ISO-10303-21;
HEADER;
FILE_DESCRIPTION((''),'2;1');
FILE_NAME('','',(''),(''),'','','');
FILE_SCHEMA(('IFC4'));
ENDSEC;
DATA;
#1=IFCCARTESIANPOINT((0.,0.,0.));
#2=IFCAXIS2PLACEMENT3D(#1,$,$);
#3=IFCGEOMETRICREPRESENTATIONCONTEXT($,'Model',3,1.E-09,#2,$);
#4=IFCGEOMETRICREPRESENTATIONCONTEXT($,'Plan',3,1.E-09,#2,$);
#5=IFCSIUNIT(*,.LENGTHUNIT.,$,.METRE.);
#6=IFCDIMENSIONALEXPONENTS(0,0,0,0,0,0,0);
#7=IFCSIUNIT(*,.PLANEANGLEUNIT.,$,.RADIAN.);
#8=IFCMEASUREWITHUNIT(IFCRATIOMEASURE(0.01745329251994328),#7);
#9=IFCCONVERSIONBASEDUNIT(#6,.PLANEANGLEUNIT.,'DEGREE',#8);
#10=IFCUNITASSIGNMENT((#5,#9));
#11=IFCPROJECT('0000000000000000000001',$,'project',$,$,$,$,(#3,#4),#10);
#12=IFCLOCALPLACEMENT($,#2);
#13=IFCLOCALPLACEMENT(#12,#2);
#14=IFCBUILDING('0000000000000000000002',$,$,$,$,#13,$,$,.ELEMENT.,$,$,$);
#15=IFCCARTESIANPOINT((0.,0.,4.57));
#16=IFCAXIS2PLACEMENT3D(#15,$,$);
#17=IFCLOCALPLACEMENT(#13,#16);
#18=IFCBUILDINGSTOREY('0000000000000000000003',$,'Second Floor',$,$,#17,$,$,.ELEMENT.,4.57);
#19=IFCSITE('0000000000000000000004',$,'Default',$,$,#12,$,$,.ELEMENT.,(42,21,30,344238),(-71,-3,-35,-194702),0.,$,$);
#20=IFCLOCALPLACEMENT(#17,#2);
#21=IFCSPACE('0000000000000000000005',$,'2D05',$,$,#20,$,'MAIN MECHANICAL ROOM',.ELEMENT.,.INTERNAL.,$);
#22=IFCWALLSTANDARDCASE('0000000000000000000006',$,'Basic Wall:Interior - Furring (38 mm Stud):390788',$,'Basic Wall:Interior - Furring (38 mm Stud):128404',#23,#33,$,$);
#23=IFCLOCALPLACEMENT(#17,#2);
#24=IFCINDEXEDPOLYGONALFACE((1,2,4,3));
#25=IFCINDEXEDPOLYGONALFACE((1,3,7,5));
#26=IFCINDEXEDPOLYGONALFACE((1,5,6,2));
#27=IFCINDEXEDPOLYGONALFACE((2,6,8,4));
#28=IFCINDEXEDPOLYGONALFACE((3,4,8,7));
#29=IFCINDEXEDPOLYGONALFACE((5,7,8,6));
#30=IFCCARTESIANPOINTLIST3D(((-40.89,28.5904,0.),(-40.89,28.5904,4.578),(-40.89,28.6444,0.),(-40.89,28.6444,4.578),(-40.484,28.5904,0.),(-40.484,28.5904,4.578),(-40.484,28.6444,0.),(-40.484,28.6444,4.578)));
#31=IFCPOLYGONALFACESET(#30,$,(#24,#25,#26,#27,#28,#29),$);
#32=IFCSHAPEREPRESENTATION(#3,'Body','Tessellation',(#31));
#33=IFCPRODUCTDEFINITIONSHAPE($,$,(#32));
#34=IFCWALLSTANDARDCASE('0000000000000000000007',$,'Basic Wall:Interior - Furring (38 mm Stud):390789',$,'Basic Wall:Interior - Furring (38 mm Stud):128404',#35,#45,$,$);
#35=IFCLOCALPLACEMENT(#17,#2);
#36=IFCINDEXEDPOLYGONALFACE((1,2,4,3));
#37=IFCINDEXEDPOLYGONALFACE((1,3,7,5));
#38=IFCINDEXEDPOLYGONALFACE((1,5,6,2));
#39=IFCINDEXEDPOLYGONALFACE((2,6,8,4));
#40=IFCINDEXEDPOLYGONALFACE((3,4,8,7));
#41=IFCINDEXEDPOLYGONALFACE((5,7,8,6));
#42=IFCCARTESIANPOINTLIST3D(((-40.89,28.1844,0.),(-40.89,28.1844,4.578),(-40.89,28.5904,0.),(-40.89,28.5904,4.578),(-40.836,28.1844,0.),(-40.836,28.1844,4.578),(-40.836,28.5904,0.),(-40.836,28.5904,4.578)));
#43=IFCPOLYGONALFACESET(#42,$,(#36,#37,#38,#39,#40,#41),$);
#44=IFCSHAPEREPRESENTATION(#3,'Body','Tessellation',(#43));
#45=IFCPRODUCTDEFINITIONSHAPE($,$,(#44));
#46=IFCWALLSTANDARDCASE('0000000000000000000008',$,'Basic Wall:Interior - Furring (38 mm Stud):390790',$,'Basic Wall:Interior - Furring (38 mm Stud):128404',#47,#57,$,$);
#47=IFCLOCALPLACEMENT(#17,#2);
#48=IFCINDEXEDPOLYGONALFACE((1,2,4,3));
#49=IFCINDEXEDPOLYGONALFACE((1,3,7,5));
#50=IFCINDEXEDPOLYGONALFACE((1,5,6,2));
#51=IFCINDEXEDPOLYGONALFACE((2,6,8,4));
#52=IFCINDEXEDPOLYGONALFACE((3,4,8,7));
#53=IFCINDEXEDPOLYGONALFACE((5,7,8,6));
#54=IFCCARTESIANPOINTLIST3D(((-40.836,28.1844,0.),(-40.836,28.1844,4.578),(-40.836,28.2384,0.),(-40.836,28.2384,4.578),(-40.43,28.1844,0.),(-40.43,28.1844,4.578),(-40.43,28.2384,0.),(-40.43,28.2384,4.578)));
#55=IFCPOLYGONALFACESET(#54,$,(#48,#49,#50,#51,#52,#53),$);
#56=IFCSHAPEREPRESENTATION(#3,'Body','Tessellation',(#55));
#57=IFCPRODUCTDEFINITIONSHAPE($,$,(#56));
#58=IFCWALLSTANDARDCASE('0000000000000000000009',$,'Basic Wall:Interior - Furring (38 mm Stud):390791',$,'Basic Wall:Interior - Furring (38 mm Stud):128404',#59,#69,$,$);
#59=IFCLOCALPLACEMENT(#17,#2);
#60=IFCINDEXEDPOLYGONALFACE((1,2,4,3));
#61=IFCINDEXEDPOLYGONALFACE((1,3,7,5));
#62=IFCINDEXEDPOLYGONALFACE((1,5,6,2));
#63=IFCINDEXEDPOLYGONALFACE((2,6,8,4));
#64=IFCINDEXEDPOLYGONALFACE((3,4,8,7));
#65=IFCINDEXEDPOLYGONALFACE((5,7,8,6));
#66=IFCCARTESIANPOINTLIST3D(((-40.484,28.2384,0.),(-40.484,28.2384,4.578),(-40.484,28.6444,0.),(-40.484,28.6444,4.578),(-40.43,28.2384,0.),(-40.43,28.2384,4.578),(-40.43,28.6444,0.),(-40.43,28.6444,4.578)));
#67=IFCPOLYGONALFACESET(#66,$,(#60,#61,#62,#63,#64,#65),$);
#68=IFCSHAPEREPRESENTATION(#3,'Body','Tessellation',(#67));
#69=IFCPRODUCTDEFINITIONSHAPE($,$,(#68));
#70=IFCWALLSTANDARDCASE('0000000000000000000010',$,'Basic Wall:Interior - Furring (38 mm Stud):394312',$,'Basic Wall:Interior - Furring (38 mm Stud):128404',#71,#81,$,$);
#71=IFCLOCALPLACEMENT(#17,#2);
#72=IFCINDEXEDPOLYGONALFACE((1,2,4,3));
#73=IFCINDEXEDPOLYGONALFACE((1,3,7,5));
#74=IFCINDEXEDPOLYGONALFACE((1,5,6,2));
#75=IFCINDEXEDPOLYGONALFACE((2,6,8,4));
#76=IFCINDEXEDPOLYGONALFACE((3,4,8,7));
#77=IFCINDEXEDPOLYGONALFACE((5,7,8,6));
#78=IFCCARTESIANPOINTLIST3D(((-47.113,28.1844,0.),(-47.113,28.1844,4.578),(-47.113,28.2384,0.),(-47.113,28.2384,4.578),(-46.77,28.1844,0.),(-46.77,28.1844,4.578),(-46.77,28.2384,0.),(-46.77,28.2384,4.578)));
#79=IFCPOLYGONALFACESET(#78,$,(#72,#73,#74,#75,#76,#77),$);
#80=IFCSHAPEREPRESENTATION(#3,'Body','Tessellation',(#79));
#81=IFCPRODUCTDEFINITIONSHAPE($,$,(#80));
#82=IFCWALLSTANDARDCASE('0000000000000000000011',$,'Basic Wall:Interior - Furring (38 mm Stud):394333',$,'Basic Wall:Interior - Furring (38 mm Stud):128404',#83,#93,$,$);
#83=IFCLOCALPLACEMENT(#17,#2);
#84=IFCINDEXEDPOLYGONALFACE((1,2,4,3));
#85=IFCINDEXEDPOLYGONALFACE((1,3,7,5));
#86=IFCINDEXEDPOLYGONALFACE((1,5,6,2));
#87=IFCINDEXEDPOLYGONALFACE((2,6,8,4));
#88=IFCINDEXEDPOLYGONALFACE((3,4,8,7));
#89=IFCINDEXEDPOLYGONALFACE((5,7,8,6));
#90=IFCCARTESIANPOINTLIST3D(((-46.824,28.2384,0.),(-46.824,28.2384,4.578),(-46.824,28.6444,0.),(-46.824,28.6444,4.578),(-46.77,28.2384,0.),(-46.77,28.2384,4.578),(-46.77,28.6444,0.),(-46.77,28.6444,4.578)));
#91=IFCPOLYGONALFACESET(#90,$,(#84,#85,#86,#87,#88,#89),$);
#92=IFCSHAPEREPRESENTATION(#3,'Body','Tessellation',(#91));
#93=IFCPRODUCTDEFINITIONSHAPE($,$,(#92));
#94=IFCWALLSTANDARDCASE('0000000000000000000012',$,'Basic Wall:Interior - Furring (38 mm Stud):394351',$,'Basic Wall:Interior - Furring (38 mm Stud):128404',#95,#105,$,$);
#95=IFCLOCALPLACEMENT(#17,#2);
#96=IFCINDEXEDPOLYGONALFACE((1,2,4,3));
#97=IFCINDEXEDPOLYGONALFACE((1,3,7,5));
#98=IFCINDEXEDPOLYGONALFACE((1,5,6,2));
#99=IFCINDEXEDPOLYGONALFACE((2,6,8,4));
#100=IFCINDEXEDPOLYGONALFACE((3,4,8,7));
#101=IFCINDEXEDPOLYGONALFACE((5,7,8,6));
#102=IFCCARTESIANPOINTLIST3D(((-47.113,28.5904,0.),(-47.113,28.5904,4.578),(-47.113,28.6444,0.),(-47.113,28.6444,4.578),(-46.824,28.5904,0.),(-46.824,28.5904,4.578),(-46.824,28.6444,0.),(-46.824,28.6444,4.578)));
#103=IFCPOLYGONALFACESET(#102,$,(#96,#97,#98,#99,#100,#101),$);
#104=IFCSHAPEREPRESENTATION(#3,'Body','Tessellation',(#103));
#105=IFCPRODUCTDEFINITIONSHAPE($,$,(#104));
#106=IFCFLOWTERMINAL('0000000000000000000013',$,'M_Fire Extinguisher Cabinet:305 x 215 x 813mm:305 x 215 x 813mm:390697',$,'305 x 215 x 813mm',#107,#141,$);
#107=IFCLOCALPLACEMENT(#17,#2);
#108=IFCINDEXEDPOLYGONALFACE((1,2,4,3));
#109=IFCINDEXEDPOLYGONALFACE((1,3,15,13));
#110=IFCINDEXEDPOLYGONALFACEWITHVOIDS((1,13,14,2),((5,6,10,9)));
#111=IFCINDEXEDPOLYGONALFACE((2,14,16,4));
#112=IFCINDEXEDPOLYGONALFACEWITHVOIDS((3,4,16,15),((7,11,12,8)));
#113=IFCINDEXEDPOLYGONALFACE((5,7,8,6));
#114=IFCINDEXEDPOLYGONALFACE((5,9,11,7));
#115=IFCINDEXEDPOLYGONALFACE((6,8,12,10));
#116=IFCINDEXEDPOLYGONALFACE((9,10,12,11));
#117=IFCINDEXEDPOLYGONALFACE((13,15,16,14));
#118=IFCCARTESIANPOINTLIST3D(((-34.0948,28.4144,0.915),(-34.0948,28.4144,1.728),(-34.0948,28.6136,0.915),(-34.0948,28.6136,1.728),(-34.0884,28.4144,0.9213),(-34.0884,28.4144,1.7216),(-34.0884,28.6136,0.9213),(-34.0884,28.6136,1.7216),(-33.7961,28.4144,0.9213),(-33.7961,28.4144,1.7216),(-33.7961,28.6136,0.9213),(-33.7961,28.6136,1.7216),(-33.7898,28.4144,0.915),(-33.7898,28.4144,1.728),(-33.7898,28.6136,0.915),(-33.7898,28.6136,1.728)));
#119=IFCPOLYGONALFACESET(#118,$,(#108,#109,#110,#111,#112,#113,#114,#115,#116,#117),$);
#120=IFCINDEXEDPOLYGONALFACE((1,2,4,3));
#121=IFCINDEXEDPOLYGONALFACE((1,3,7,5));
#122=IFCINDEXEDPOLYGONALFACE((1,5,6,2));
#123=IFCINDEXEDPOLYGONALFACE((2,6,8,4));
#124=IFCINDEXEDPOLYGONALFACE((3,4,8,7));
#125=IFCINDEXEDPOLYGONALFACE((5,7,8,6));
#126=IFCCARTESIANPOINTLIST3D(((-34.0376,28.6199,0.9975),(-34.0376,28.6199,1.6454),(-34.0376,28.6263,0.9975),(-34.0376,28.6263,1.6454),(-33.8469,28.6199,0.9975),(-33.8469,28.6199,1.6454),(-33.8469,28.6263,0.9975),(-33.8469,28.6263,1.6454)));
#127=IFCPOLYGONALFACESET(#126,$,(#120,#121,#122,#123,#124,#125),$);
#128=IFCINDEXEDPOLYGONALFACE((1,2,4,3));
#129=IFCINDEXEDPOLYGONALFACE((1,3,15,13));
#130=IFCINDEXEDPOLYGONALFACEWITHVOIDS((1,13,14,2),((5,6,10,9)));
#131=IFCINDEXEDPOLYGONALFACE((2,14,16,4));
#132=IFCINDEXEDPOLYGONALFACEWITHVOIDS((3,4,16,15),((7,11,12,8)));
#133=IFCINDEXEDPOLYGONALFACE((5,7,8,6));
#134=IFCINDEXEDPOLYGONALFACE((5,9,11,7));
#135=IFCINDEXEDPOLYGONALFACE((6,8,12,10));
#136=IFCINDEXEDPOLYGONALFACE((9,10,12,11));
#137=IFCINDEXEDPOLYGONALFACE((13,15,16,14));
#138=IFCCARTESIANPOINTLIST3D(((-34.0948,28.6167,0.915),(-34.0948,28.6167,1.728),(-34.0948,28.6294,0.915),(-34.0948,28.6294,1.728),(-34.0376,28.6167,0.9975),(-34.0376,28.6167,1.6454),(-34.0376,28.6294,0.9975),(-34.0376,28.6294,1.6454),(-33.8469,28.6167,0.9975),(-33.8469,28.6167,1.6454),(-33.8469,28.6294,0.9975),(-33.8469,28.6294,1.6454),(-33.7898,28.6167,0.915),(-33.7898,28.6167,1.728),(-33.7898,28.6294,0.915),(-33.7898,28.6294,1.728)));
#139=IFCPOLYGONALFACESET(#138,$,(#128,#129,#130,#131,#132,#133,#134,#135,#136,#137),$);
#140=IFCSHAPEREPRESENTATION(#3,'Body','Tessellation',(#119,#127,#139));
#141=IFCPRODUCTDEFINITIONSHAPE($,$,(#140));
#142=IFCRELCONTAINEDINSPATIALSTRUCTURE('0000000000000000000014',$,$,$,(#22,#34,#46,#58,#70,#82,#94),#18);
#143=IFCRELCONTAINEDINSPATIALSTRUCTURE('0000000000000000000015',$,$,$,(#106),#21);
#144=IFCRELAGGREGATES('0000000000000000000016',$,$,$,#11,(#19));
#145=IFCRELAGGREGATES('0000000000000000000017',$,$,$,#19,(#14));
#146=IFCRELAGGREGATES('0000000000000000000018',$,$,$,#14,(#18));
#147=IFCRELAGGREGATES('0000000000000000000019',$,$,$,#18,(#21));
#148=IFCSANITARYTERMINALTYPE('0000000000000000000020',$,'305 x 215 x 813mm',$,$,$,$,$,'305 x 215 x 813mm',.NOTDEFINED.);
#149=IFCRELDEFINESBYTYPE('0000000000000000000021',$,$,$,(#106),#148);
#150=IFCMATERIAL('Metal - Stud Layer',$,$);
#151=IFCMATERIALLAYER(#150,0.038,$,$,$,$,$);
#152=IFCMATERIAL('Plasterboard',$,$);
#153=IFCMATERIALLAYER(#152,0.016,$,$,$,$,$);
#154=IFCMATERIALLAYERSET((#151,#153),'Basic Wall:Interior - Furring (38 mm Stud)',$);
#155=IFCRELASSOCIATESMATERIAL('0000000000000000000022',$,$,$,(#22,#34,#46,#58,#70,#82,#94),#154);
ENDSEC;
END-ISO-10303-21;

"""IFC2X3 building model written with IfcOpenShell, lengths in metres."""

from ifc_helpers import new_model, entity, si_unit, converted_unit, frame, frame_2d, origin, origin_2d_with_axis, place, context, project, spatial, polyline, rectangle, outline, extrude, source, transform, mapped, material, layer, layer_set, layer_usage, type_object, type_shapes, element, save


model = new_model("IFC2X3")

# Units and contexts
model_context = context("Model", 3, precision=1e-09, world=origin())
plan_context = context("Plan", 3, precision=1e-09, world=origin())
ifc_project = project(units=[si_unit("LENGTHUNIT", "METRE"), converted_unit("PLANEANGLEUNIT", "DEGREE", entity("IfcRatioMeasure", 0.01745329251994328), si_unit("PLANEANGLEUNIT", "RADIAN"), dimensions=[0, 0, 0, 0, 0, 0, 0])], contexts=[model_context, plan_context])

# Site, building, storey
site_placement = place(None, origin())
site = spatial("IfcSite", under=ifc_project, at=site_placement, Name="Default", CompositionType="ELEMENT", RefLatitude=(42, 21, 30, 344238), RefLongitude=(-71, -3, -35, -194702), RefElevation=0.0)
building_placement = place(site_placement, origin())
building = spatial("IfcBuilding", under=site, at=building_placement, CompositionType="ELEMENT")
storey_placement = place(building_placement, frame((0.0, 0.0, 4.57)))
storey = spatial("IfcBuildingStorey", under=building, at=storey_placement, Name="Second Floor", CompositionType="ELEMENT", Elevation=4.57)

# Shared definitions
ifc_material_1 = material(Name="Plasterboard")
ifc_layer_1 = layer(ifc_material_1, 0.016)
ifc_material_2 = material(Name="Metal - Stud Layer")
ifc_layer_2 = layer(ifc_material_2, 0.038)
ifc_layer_set_1 = layer_set([ifc_layer_2, ifc_layer_1], Name="Basic Wall:Interior - Furring (38 mm Stud)")
ifc_layer_usage_1 = layer_usage(ifc_layer_set_1, "AXIS2", "NEGATIVE", 0.027)

# Walls
ifc_layer_usage_2 = layer_usage(ifc_layer_set_1, "AXIS2", "POSITIVE", -0.027)
wall_1_placement = place(storey_placement, frame((-40.89, 28.6174, 0.0)))
element("IfcWallStandardCase", 1, at=wall_1_placement, inside=storey, material=ifc_layer_usage_2, Name="Basic Wall:Interior - Furring (38 mm Stud):390788", ObjectType="Basic Wall:Interior - Furring (38 mm Stud):128404", context=model_context, shape_type="SweptSolid", body=[
    extrude(rectangle(XDim=0.406, YDim=0.054, at=frame_2d((0.203, 0.0), x_axis=(-1.0, 0.0))), origin(), (0.0, 0.0, 1.0), 4.578),
])
wall_2_placement = place(storey_placement, frame((-40.863, 28.1844, 0.0), z_axis=(0.0, 0.0, 1.0), x_axis=(0.0, 1.0, 0.0)))
element("IfcWallStandardCase", 2, at=wall_2_placement, inside=storey, material=ifc_layer_usage_2, Name="Basic Wall:Interior - Furring (38 mm Stud):390789", ObjectType="Basic Wall:Interior - Furring (38 mm Stud):128404", context=model_context, shape_type="SweptSolid", body=[
    extrude(rectangle(XDim=0.406, YDim=0.054, at=frame_2d((0.203, 0.0), x_axis=(-1.0, 0.0))), origin(), (0.0, 0.0, 1.0), 4.578),
])
wall_3_placement = place(storey_placement, frame((-40.43, 28.2114, 0.0), z_axis=(0.0, 0.0, 1.0), x_axis=(-1.0, 0.0, 0.0)))
element("IfcWallStandardCase", 3, at=wall_3_placement, inside=storey, material=ifc_layer_usage_2, Name="Basic Wall:Interior - Furring (38 mm Stud):390790", ObjectType="Basic Wall:Interior - Furring (38 mm Stud):128404", context=model_context, shape_type="SweptSolid", body=[
    extrude(rectangle(XDim=0.406, YDim=0.054, at=frame_2d((0.203, 0.0), x_axis=(-1.0, 0.0))), origin(), (0.0, 0.0, 1.0), 4.578),
])
wall_4_placement = place(storey_placement, frame((-40.457, 28.6444, 0.0), z_axis=(0.0, 0.0, 1.0), x_axis=(0.0, -1.0, 0.0)))
element("IfcWallStandardCase", 4, at=wall_4_placement, inside=storey, material=ifc_layer_usage_2, Name="Basic Wall:Interior - Furring (38 mm Stud):390791", ObjectType="Basic Wall:Interior - Furring (38 mm Stud):128404", context=model_context, shape_type="SweptSolid", body=[
    extrude(rectangle(XDim=0.406, YDim=0.054, at=frame_2d((0.203, 0.0), x_axis=(-1.0, 0.0))), origin(), (0.0, 0.0, 1.0), 4.578),
])
wall_5_placement = place(storey_placement, frame((-47.113, 28.2114, 0.0)))
element("IfcWallStandardCase", 5, at=wall_5_placement, inside=storey, material=ifc_layer_usage_1, Name="Basic Wall:Interior - Furring (38 mm Stud):394312", ObjectType="Basic Wall:Interior - Furring (38 mm Stud):128404", context=model_context, shape_type="SweptSolid", body=[
    extrude(rectangle(XDim=0.343, YDim=0.054, at=frame_2d((0.1715, 0.0), x_axis=(-1.0, 0.0))), origin(), (0.0, 0.0, 1.0), 4.578),
])
wall_6_placement = place(storey_placement, frame((-46.797, 28.2384, 0.0), z_axis=(0.0, 0.0, 1.0), x_axis=(0.0, 1.0, 0.0)))
element("IfcWallStandardCase", 6, at=wall_6_placement, inside=storey, material=ifc_layer_usage_1, Name="Basic Wall:Interior - Furring (38 mm Stud):394333", ObjectType="Basic Wall:Interior - Furring (38 mm Stud):128404", context=model_context, shape_type="SweptSolid", body=[
    extrude(rectangle(XDim=0.406, YDim=0.054, at=frame_2d((0.203, 0.0), x_axis=(-1.0, 0.0))), origin(), (0.0, 0.0, 1.0), 4.578),
])
wall_7_placement = place(storey_placement, frame((-46.824, 28.6174, 0.0), z_axis=(0.0, 0.0, 1.0), x_axis=(-1.0, 0.0, 0.0)))
element("IfcWallStandardCase", 7, at=wall_7_placement, inside=storey, material=ifc_layer_usage_1, Name="Basic Wall:Interior - Furring (38 mm Stud):394351", ObjectType="Basic Wall:Interior - Furring (38 mm Stud):128404", context=model_context, shape_type="SweptSolid", body=[
    extrude(rectangle(XDim=0.289, YDim=0.054, at=frame_2d((0.1445, 0.0), x_axis=(-1.0, 0.0))), origin(), (0.0, 0.0, 1.0), 4.578),
])

# Shared definitions
space_placement = place(storey_placement, origin())
space = spatial("IfcSpace", under=storey, at=space_placement, Name="2D05", LongName="MAIN MECHANICAL ROOM", CompositionType="ELEMENT", InteriorOrExteriorSpace="INTERNAL")

# Flow terminal
sanitary_terminal_type = type_object("IfcSanitaryTerminalType", Name="305 x 215 x 813mm", ElementType="305 x 215 x 813mm", PredefinedType="NOTDEFINED")
shared_shape_1 = source(origin(), model_context, "Body", "SweptSolid", [
    extrude(outline(polyline([(-0.1525, -0.4065), (0.1525, -0.4065), (0.1525, 0.4065), (-0.1525, 0.4065), (-0.1525, -0.4065)]), holes=[polyline([(-0.1462, -0.4001), (-0.1462, 0.4002), (0.1462, 0.4002), (0.1462, -0.4001), (-0.1462, -0.4001)])]), frame((-0.1096, 0.027, 1.3215), z_axis=(0.0, 1.0, 0.0), x_axis=(1.0, 0.0, 0.0)), (0.0, 0.0, 1.0), 0.1991),
    extrude(rectangle(XDim=0.0064, YDim=0.1907, at=origin_2d_with_axis()), frame((-0.1096, 0.2356, 0.9975), z_axis=(0.0, 0.0, 1.0), x_axis=(0.0, -1.0, 0.0)), (0.0, 0.0, 1.0), 0.6479),
    extrude(outline(polyline([(-0.1525, -0.4065), (0.1525, -0.4065), (0.1525, 0.4065), (-0.1525, 0.4065), (-0.1525, -0.4065)]), holes=[polyline([(-0.0953, -0.3239), (-0.0953, 0.324), (0.0954, 0.324), (0.0954, -0.3239), (-0.0953, -0.3239)])]), frame((-0.1096, 0.2293, 1.3215), z_axis=(0.0, 1.0, 0.0), x_axis=(1.0, 0.0, 0.0)), (0.0, 0.0, 1.0), 0.0127),
])
type_shapes(sanitary_terminal_type, [shared_shape_1])
flow_terminal_placement = place(space_placement, frame((-33.8326, 28.3874, 0.0)))
element("IfcFlowTerminal", 8, at=flow_terminal_placement, inside=space, type_object=sanitary_terminal_type, Name="M_Fire Extinguisher Cabinet:305 x 215 x 813mm:305 x 215 x 813mm:390697", ObjectType="305 x 215 x 813mm", context=model_context, shape_type="MappedRepresentation", body=[
    mapped(shared_shape_1, transform((0.0, 0.0, 0.0), scale=1.0)),
])

save(model, "model.ifc")
